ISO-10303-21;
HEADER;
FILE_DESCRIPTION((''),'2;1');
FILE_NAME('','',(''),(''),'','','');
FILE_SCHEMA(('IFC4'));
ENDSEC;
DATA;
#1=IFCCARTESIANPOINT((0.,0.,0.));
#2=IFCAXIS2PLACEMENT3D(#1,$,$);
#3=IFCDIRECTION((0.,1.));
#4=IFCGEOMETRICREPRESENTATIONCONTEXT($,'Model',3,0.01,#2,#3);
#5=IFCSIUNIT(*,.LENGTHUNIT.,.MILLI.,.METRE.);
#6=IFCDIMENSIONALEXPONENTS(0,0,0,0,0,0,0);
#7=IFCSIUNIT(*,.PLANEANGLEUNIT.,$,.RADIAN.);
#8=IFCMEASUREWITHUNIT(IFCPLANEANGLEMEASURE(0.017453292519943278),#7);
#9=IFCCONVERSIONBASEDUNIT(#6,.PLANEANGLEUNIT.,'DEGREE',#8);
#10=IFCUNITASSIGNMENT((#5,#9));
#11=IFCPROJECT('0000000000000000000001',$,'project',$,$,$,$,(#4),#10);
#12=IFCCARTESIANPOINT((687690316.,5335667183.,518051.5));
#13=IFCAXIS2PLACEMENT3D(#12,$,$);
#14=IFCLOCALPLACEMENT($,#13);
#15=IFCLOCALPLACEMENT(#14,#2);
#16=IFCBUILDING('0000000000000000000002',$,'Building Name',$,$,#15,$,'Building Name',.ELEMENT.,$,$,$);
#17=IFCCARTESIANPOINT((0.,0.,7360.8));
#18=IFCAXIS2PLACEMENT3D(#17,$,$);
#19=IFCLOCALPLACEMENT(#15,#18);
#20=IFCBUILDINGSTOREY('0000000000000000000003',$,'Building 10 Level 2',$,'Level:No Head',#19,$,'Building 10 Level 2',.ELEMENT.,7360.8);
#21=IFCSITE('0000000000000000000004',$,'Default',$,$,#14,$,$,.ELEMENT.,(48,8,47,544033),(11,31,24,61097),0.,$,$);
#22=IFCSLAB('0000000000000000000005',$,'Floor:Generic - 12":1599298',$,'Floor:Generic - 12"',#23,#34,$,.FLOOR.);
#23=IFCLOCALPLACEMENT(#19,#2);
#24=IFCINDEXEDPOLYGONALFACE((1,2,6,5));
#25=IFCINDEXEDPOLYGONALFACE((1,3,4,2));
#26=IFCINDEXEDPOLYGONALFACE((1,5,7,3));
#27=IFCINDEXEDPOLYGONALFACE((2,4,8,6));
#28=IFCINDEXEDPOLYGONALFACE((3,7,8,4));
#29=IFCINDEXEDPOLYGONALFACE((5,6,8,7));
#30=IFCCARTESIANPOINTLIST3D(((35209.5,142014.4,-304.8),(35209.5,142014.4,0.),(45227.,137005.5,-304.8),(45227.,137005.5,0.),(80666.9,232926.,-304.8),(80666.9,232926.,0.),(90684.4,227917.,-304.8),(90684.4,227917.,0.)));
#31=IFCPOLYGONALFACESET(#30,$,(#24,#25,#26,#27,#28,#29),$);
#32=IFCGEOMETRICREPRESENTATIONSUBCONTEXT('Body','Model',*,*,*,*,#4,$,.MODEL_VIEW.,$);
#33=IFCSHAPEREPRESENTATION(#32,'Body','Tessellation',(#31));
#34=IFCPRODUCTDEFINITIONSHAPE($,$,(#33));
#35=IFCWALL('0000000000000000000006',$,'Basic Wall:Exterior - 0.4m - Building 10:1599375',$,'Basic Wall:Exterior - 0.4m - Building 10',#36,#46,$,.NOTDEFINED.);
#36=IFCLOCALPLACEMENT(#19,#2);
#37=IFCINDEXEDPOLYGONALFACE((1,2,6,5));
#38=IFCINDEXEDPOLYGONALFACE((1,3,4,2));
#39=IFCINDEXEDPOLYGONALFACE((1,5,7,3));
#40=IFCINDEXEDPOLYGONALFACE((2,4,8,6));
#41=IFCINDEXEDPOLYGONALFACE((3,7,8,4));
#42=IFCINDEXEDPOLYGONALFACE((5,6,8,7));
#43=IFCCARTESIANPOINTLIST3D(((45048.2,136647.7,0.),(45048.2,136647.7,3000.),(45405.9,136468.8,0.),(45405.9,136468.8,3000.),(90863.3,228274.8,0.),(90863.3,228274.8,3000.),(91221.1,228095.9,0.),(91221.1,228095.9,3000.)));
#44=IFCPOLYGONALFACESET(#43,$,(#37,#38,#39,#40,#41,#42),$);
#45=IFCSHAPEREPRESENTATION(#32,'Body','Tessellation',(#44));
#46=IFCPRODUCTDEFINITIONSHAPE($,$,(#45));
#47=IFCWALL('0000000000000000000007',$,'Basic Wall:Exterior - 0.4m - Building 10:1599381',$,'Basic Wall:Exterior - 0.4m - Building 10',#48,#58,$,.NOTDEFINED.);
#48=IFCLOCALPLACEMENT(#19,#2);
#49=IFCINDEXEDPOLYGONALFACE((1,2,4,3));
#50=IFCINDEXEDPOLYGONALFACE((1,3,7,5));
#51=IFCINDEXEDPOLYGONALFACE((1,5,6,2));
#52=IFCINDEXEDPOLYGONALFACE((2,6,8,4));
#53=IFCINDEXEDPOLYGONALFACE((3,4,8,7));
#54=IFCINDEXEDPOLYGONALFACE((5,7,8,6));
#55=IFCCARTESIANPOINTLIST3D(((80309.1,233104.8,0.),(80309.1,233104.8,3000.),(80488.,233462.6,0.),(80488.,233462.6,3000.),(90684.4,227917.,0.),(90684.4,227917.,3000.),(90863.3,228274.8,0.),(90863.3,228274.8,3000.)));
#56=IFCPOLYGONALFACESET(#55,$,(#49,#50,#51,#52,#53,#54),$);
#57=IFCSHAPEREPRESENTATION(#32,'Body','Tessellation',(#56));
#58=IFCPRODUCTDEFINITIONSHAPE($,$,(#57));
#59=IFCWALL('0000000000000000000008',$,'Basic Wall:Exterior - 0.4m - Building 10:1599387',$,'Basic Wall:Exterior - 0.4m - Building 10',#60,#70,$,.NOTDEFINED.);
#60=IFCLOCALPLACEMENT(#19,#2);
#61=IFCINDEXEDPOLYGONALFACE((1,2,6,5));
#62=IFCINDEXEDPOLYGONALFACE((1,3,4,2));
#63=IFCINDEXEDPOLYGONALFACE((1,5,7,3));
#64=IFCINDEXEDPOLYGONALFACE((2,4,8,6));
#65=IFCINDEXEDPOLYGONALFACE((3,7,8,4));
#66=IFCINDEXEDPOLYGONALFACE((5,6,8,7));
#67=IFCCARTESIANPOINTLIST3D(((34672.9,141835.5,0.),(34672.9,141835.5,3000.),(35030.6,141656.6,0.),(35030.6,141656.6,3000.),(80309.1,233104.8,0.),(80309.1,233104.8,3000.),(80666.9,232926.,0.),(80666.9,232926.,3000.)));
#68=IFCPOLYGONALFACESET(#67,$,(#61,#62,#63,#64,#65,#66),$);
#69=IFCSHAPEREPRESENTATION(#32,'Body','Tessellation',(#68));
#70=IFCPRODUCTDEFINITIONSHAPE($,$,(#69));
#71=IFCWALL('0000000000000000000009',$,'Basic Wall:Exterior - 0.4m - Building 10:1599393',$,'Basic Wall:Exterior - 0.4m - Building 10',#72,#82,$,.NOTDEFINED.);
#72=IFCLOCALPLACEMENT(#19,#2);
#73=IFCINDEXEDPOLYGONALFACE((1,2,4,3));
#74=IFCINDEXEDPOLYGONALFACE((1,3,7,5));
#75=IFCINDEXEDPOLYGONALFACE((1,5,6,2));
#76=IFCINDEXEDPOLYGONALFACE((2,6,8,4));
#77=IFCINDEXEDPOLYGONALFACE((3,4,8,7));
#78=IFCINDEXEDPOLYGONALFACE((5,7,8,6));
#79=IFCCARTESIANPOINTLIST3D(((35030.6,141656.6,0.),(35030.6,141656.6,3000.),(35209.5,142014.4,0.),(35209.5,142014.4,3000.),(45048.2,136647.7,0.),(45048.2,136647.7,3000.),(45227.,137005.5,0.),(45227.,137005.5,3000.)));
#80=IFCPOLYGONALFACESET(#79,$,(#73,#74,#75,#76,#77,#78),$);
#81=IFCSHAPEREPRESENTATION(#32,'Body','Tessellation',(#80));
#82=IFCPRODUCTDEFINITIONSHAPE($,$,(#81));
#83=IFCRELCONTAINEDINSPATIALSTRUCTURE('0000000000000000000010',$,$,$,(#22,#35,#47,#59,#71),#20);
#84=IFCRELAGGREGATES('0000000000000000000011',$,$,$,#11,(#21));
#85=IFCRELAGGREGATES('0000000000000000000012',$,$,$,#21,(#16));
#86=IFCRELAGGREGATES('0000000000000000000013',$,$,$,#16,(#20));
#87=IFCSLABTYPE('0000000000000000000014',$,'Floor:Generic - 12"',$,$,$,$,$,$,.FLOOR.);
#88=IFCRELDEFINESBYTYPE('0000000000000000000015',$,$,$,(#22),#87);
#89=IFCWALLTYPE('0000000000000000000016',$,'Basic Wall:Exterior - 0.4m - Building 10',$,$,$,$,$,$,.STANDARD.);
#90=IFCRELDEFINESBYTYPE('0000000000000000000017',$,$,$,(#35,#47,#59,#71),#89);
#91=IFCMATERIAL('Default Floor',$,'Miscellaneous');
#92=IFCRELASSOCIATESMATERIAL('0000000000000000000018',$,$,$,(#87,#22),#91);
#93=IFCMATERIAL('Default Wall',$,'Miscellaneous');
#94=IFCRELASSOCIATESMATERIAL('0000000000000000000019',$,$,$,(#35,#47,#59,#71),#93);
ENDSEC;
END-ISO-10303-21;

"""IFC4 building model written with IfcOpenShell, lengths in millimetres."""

from ifc_helpers import new_model, entity, si_unit, converted_unit, direction, frame, origin, place, context, subcontext, project, spatial, indexed_curve, outline, extrude, material, type_object, element, save


model = new_model("IFC4")

# Units and contexts
model_context = context("Model", 3, precision=0.01, world=origin(), true_north=direction((0.0, 1.0)))
body_context = subcontext(model_context, "Body", "Model", "MODEL_VIEW")
ifc_project = project(units=[si_unit("LENGTHUNIT", "METRE", prefix="MILLI"), converted_unit("PLANEANGLEUNIT", "DEGREE", entity("IfcPlaneAngleMeasure", 0.017453292519943278), si_unit("PLANEANGLEUNIT", "RADIAN"), dimensions=[0, 0, 0, 0, 0, 0, 0])], contexts=[model_context])

# Site, building, storey
site_placement = place(None, frame((687690316.0, 5335667183.0, 518051.5)))
site = spatial("IfcSite", under=ifc_project, at=site_placement, Name="Default", CompositionType="ELEMENT", RefLatitude=(48, 8, 47, 544033), RefLongitude=(11, 31, 24, 61097), RefElevation=0.0)
building_placement = place(site_placement, origin())
building = spatial("IfcBuilding", under=site, at=building_placement, Name="Building Name", LongName="Building Name", CompositionType="ELEMENT")
storey_placement = place(building_placement, frame((0.0, 0.0, 7360.8)))
storey = spatial("IfcBuildingStorey", under=building, at=storey_placement, Name="Building 10 Level 2", ObjectType="Level:No Head", LongName="Building 10 Level 2", CompositionType="ELEMENT", Elevation=7360.8)

# Slab
ifc_material_1 = material(Name="Default Floor", Category="Miscellaneous")
slab_type = type_object("IfcSlabType", Name="Floor:Generic - 12\"", PredefinedType="FLOOR", material=ifc_material_1)
slab_placement = place(storey_placement, origin())
element("IfcSlab", 1, at=slab_placement, inside=storey, type_object=slab_type, material=ifc_material_1, Name="Floor:Generic - 12\":1599298", ObjectType="Floor:Generic - 12\"", PredefinedType="FLOOR", context=body_context, shape_type="SweptSolid", body=[
    extrude(outline(indexed_curve([(-50821.4, -5600.0), (50821.4, -5600.0), (50821.4, 5600.0), (-50821.4, 5600.0), (-50821.4, -5600.0)], self_intersect=False)), frame((62947.0, 184965.7, 0.0), z_axis=(0.0, 0.0, -1.0), x_axis=(-0.447226, -0.894421, 0.0)), (0.0, 0.0, 1.0), 304.8),
])

# Walls
ifc_material_2 = material(Name="Default Wall", Category="Miscellaneous")
wall_type = type_object("IfcWallType", Name="Basic Wall:Exterior - 0.4m - Building 10", PredefinedType="STANDARD")
wall_1_placement = place(storey_placement, frame((45227.0, 136558.3, 0.0), z_axis=(0.0, 0.0, 1.0), x_axis=(0.447226, 0.894421, 0.0)))
element("IfcWall", 2, at=wall_1_placement, inside=storey, type_object=wall_type, material=ifc_material_2, Name="Basic Wall:Exterior - 0.4m - Building 10:1599375", ObjectType="Basic Wall:Exterior - 0.4m - Building 10", PredefinedType="NOTDEFINED", context=body_context, shape_type="SweptSolid", body=[
    extrude(outline(indexed_curve([(102442.9, 200.0), (0.0, 200.0), (0.0, -200.0), (102442.9, -200.0), (102442.9, 200.0)], self_intersect=False)), origin(), (0.0, 0.0, 1.0), 3000.0),
])
wall_2_placement = place(storey_placement, frame((90773.8, 228095.9, 0.0), z_axis=(0.0, 0.0, 1.0), x_axis=(-0.894421, 0.447226, 0.0)))
element("IfcWall", 3, at=wall_2_placement, inside=storey, type_object=wall_type, material=ifc_material_2, Name="Basic Wall:Exterior - 0.4m - Building 10:1599381", ObjectType="Basic Wall:Exterior - 0.4m - Building 10", PredefinedType="NOTDEFINED", context=body_context, shape_type="SweptSolid", body=[
    extrude(outline(indexed_curve([(11600.0, 200.0), (0.0, 200.0), (0.0, -200.0), (11600.0, -200.0), (11600.0, 200.0)], self_intersect=False)), origin(), (0.0, 0.0, 1.0), 3000.0),
])
wall_3_placement = place(storey_placement, frame((80488.0, 233015.4, 0.0), z_axis=(0.0, 0.0, 1.0), x_axis=(-0.447226, -0.894421, 0.0)))
element("IfcWall", 4, at=wall_3_placement, inside=storey, type_object=wall_type, material=ifc_material_2, Name="Basic Wall:Exterior - 0.4m - Building 10:1599387", ObjectType="Basic Wall:Exterior - 0.4m - Building 10", PredefinedType="NOTDEFINED", context=body_context, shape_type="SweptSolid", body=[
    extrude(outline(indexed_curve([(102042.9, 200.0), (0.0, 200.0), (0.0, -200.0), (102042.9, -200.0), (102042.9, 200.0)], self_intersect=False)), origin(), (0.0, 0.0, 1.0), 3000.0),
])
wall_4_placement = place(storey_placement, frame((35120.1, 141835.5, 0.0), z_axis=(0.0, 0.0, 1.0), x_axis=(0.894421, -0.447226, 0.0)))
element("IfcWall", 5, at=wall_4_placement, inside=storey, type_object=wall_type, material=ifc_material_2, Name="Basic Wall:Exterior - 0.4m - Building 10:1599393", ObjectType="Basic Wall:Exterior - 0.4m - Building 10", PredefinedType="NOTDEFINED", context=body_context, shape_type="SweptSolid", body=[
    extrude(outline(indexed_curve([(11200.0, 200.0), (0.0, 200.0), (0.0, -200.0), (11200.0, -200.0), (11200.0, 200.0)], self_intersect=False)), origin(), (0.0, 0.0, 1.0), 3000.0),
])

save(model, "model.ifc")
